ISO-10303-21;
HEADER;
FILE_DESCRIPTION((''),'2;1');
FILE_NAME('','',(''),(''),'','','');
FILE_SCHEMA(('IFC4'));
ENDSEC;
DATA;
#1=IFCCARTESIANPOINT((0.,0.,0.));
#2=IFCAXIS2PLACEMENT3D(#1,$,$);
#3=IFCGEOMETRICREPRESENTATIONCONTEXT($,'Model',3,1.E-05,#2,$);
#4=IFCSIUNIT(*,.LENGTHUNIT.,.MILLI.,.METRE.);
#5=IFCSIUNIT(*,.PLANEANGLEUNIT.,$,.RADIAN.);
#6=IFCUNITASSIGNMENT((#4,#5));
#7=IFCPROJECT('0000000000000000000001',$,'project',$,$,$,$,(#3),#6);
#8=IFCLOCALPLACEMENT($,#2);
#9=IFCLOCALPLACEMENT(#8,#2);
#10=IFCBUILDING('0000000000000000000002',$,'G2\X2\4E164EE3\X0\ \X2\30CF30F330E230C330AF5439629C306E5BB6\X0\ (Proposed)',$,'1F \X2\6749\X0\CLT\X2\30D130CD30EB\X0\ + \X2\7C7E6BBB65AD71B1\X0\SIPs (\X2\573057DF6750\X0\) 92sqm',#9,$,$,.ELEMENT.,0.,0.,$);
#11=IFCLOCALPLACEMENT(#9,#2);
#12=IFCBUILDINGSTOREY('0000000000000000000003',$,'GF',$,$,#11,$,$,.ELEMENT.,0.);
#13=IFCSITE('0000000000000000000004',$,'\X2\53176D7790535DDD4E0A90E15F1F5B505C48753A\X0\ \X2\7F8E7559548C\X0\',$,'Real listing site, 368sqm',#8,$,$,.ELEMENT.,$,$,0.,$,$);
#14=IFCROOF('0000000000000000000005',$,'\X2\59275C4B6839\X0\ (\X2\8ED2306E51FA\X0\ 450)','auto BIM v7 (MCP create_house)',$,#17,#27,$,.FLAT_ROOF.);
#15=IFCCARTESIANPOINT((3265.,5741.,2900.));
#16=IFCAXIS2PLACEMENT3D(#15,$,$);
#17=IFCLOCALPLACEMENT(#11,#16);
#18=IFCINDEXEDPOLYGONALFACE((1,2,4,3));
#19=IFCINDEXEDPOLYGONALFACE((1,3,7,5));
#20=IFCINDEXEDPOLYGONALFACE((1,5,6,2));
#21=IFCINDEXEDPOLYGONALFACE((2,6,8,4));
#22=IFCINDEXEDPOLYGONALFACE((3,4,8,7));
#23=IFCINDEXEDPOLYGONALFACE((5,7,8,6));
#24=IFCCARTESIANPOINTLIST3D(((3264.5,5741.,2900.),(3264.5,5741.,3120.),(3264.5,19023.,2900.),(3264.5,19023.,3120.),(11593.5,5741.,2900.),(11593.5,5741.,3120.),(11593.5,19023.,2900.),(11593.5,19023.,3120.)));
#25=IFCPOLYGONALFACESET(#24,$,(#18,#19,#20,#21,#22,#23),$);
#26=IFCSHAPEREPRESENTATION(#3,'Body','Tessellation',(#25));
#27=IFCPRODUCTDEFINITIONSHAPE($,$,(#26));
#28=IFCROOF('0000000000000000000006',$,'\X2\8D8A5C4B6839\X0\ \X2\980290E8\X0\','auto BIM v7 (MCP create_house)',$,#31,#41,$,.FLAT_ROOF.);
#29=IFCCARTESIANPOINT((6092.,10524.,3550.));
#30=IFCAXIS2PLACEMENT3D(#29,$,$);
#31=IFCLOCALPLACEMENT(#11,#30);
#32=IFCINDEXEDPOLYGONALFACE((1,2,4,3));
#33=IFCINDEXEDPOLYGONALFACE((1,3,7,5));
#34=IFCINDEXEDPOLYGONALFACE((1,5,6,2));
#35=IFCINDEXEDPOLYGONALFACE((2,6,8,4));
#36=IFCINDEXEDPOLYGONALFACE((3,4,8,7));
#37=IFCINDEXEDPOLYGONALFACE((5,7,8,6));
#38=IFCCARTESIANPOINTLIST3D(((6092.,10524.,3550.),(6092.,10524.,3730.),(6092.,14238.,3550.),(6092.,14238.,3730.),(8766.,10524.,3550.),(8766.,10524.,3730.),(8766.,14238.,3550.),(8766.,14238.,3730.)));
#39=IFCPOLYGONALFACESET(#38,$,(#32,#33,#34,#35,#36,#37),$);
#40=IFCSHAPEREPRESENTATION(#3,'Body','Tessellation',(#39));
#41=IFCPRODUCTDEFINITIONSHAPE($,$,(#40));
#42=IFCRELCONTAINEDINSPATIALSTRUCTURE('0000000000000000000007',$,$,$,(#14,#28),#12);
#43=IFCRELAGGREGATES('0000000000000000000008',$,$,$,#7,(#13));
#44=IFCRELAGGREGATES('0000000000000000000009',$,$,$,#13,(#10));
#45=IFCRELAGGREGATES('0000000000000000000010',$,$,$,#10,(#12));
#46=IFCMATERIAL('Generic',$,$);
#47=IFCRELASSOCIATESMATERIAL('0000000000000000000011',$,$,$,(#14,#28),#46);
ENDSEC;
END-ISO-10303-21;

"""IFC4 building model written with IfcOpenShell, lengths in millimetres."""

from ifc_helpers import new_model, si_unit, frame, frame_2d, origin, place, context, project, spatial, rectangle, extrude, material, element, save


model = new_model("IFC4")

# Units and contexts
model_context = context("Model", 3, precision=1e-05, world=origin())
ifc_project = project(units=[si_unit("LENGTHUNIT", "METRE", prefix="MILLI"), si_unit("PLANEANGLEUNIT", "RADIAN")], contexts=[model_context])

# Site, building, storey
site_placement = place(None, origin())
site = spatial("IfcSite", under=ifc_project, at=site_placement, Name="北海道川上郡弟子屈町 美留和", ObjectType="Real listing site, 368sqm", CompositionType="ELEMENT", RefElevation=0.0)
building_placement = place(site_placement, origin())
building = spatial("IfcBuilding", under=site, at=building_placement, Name="G2世代 ハンモック吹抜の家 (Proposed)", ObjectType="1F 杉CLTパネル + 籾殻断熱SIPs (地域材) 92sqm", CompositionType="ELEMENT", ElevationOfRefHeight=0.0, ElevationOfTerrain=0.0)
storey_placement = place(building_placement, origin())
storey = spatial("IfcBuildingStorey", under=building, at=storey_placement, Name="GF", CompositionType="ELEMENT", Elevation=0.0)

# Shared definitions
ifc_material = material(Name="Generic")

# Roofs
roof_1_placement = place(storey_placement, frame((3265.0, 5741.0, 2900.0)))
element("IfcRoof", 1, at=roof_1_placement, inside=storey, material=ifc_material, Name="大屋根 (軒の出 450)", Description="auto BIM v7 (MCP create_house)", PredefinedType="FLAT_ROOF", context=model_context, shape_type="SweptSolid", body=[
    extrude(rectangle(XDim=8329.0, YDim=13282.0, at=frame_2d((4164.0, 6641.0))), frame((3265.0, 5741.0, 2900.0)), (0.0, 0.0, 1.0), 220.0),
])
roof_2_placement = place(storey_placement, frame((6092.0, 10524.0, 3550.0)))
element("IfcRoof", 2, at=roof_2_placement, inside=storey, material=ifc_material, Name="越屋根 頂部", Description="auto BIM v7 (MCP create_house)", PredefinedType="FLAT_ROOF", context=model_context, shape_type="SweptSolid", body=[
    extrude(rectangle(XDim=2674.0, YDim=3714.0, at=frame_2d((1337.0, 1857.0))), frame((6092.0, 10524.0, 3550.0)), (0.0, 0.0, 1.0), 180.0),
])

save(model, "model.ifc")
